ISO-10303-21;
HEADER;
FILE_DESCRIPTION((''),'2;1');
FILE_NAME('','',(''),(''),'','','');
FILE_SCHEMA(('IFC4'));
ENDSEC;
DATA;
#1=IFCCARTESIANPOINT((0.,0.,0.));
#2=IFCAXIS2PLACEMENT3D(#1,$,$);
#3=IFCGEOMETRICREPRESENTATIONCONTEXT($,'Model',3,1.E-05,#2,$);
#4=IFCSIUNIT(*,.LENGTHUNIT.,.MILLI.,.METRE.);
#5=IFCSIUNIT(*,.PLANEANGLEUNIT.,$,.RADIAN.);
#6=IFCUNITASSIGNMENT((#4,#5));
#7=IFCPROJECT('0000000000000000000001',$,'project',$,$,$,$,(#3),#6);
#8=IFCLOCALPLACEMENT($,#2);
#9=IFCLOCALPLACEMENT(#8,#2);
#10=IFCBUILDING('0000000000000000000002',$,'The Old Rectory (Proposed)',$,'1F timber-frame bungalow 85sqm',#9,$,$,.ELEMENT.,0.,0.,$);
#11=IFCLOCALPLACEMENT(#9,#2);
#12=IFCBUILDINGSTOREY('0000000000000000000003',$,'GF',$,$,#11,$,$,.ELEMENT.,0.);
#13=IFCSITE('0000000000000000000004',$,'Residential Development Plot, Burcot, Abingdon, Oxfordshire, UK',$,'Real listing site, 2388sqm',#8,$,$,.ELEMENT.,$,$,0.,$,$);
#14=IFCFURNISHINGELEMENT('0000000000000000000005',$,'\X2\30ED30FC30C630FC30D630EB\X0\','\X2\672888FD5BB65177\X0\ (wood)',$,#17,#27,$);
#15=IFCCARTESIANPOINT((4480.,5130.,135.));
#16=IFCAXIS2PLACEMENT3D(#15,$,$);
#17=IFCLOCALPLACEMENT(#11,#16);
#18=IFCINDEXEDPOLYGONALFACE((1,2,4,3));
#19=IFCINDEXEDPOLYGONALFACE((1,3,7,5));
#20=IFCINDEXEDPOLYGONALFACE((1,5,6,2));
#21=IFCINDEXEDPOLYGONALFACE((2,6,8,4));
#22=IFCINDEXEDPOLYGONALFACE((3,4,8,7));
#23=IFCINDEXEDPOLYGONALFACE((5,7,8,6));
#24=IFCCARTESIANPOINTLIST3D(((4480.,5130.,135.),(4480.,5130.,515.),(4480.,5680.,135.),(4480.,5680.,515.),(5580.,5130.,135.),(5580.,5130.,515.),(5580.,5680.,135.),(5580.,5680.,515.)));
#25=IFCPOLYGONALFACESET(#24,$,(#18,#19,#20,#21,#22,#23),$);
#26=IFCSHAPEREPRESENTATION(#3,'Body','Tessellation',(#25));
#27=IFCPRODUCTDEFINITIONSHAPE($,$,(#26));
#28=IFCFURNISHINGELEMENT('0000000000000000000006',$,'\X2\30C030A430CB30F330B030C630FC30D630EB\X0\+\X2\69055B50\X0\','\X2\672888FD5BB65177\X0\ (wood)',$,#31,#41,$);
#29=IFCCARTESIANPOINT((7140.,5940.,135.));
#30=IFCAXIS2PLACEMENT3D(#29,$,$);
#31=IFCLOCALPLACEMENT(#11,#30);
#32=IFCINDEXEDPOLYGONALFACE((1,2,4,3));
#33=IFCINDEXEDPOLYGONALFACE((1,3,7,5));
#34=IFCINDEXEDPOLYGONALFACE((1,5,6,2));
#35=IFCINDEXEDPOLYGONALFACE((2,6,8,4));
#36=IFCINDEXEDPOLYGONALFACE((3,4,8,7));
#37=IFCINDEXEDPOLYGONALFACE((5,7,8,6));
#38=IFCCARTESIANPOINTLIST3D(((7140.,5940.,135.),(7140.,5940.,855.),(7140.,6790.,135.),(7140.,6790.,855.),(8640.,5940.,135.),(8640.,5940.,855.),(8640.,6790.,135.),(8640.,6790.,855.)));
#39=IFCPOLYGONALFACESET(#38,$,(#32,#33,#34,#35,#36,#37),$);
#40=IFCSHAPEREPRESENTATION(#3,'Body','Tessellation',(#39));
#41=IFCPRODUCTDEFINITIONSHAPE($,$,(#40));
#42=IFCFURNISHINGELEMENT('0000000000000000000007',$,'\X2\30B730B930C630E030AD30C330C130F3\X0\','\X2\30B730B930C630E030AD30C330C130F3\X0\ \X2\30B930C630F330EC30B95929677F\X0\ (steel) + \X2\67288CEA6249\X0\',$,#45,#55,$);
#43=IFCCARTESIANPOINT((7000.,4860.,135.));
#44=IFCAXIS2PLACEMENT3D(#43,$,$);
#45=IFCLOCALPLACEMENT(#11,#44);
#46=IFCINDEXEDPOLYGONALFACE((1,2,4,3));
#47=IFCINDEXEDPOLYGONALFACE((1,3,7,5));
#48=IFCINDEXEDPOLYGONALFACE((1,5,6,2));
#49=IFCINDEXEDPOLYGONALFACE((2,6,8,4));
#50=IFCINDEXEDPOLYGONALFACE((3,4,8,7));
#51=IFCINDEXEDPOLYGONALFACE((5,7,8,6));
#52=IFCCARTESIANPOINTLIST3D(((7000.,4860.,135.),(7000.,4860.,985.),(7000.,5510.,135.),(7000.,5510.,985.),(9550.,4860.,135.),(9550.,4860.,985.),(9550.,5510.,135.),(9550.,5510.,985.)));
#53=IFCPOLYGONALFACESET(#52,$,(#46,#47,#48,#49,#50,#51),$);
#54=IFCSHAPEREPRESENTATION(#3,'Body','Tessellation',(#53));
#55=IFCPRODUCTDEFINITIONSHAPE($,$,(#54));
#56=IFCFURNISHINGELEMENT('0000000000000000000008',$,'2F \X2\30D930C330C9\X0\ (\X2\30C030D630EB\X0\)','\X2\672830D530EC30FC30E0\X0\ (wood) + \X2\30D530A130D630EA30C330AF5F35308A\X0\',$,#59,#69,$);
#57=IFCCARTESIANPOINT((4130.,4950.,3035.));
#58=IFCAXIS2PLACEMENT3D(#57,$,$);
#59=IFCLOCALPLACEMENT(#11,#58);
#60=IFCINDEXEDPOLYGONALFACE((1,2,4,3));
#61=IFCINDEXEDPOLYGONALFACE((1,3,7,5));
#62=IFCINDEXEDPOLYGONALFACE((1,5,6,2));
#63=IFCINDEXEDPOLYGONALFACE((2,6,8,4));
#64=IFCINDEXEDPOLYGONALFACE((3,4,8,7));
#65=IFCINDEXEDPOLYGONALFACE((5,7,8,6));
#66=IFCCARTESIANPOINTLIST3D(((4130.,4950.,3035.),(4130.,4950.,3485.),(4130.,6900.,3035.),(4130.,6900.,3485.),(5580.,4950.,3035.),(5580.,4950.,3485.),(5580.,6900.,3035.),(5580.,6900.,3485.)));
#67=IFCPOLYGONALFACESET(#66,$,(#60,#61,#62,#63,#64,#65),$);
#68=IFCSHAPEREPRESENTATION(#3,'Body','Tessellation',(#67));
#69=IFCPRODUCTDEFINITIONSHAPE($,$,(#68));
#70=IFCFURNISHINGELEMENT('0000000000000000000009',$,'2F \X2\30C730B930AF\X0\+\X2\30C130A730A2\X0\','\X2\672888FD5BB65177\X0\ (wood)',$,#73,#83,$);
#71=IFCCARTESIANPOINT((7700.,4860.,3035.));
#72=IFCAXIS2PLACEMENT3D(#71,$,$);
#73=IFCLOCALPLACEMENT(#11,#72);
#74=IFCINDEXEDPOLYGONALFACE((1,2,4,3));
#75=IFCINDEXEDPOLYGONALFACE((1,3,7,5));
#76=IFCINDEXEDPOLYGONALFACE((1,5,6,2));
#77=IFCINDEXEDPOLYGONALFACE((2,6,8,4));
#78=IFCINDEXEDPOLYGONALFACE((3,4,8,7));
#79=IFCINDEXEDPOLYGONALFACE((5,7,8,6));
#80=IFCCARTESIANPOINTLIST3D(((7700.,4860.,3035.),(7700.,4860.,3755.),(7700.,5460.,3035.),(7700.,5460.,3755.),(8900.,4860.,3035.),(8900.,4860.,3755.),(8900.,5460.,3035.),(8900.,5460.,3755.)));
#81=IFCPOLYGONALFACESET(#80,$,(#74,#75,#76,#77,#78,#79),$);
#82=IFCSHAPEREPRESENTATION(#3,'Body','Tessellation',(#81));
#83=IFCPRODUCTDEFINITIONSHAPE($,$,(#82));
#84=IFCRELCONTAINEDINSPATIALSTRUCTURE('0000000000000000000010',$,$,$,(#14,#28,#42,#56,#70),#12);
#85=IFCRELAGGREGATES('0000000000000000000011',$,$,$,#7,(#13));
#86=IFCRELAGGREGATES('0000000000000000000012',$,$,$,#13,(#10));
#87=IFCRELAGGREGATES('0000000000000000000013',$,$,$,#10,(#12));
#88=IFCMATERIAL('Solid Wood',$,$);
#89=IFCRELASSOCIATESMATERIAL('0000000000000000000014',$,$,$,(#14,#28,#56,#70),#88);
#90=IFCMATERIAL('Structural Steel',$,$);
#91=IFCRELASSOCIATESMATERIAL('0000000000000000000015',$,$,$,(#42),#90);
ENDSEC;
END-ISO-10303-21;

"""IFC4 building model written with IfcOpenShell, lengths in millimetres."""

from ifc_helpers import new_model, si_unit, frame, frame_2d, origin, place, context, project, spatial, rectangle, extrude, material, element, save


model = new_model("IFC4")

# Units and contexts
model_context = context("Model", 3, precision=1e-05, world=origin())
ifc_project = project(units=[si_unit("LENGTHUNIT", "METRE", prefix="MILLI"), si_unit("PLANEANGLEUNIT", "RADIAN")], contexts=[model_context])

# Site, building, storey
site_placement = place(None, origin())
site = spatial("IfcSite", under=ifc_project, at=site_placement, Name="Residential Development Plot, Burcot, Abingdon, Oxfordshire, UK", ObjectType="Real listing site, 2388sqm", CompositionType="ELEMENT", RefElevation=0.0)
building_placement = place(site_placement, origin())
building = spatial("IfcBuilding", under=site, at=building_placement, Name="The Old Rectory (Proposed)", ObjectType="1F timber-frame bungalow 85sqm", CompositionType="ELEMENT", ElevationOfRefHeight=0.0, ElevationOfTerrain=0.0)
storey_placement = place(building_placement, origin())
storey = spatial("IfcBuildingStorey", under=building, at=storey_placement, Name="GF", CompositionType="ELEMENT", Elevation=0.0)

# Shared definitions
ifc_material_1 = material(Name="Solid Wood")

# Shared definitions
ifc_material_2 = material(Name="Structural Steel")

# Furnishing elements
furnishing_1_placement = place(storey_placement, frame((4480.0, 5130.0, 135.0)))
element("IfcFurnishingElement", 1, at=furnishing_1_placement, inside=storey, material=ifc_material_1, Name="ローテーブル", Description="木製家具 (wood)", context=model_context, shape_type="SweptSolid", body=[
    extrude(rectangle(XDim=1100.0, YDim=550.0, at=frame_2d((550.0, 275.0))), frame((4480.0, 5130.0, 135.0)), (0.0, 0.0, 1.0), 380.0),
])
furnishing_2_placement = place(storey_placement, frame((7140.0, 5940.0, 135.0)))
element("IfcFurnishingElement", 2, at=furnishing_2_placement, inside=storey, material=ifc_material_1, Name="ダイニングテーブル+椅子", Description="木製家具 (wood)", context=model_context, shape_type="SweptSolid", body=[
    extrude(rectangle(XDim=1500.0, YDim=850.0, at=frame_2d((750.0, 425.0))), frame((7140.0, 5940.0, 135.0)), (0.0, 0.0, 1.0), 720.0),
])
furnishing_3_placement = place(storey_placement, frame((7000.0, 4860.0, 135.0)))
element("IfcFurnishingElement", 3, at=furnishing_3_placement, inside=storey, material=ifc_material_2, Name="システムキッチン", Description="システムキッチン ステンレス天板 (steel) + 木質扉", context=model_context, shape_type="SweptSolid", body=[
    extrude(rectangle(XDim=2550.0, YDim=650.0, at=frame_2d((1275.0, 325.0))), frame((7000.0, 4860.0, 135.0)), (0.0, 0.0, 1.0), 850.0),
])
furnishing_4_placement = place(storey_placement, frame((4130.0, 4950.0, 3035.0)))
element("IfcFurnishingElement", 4, at=furnishing_4_placement, inside=storey, material=ifc_material_1, Name="2F ベッド (ダブル)", Description="木フレーム (wood) + ファブリック張り", context=model_context, shape_type="SweptSolid", body=[
    extrude(rectangle(XDim=1450.0, YDim=1950.0, at=frame_2d((725.0, 975.0))), frame((4130.0, 4950.0, 3035.0)), (0.0, 0.0, 1.0), 450.0),
])
furnishing_5_placement = place(storey_placement, frame((7700.0, 4860.0, 3035.0)))
element("IfcFurnishingElement", 5, at=furnishing_5_placement, inside=storey, material=ifc_material_1, Name="2F デスク+チェア", Description="木製家具 (wood)", context=model_context, shape_type="SweptSolid", body=[
    extrude(rectangle(XDim=1200.0, YDim=600.0, at=frame_2d((600.0, 300.0))), frame((7700.0, 4860.0, 3035.0)), (0.0, 0.0, 1.0), 720.0),
])

save(model, "model.ifc")
